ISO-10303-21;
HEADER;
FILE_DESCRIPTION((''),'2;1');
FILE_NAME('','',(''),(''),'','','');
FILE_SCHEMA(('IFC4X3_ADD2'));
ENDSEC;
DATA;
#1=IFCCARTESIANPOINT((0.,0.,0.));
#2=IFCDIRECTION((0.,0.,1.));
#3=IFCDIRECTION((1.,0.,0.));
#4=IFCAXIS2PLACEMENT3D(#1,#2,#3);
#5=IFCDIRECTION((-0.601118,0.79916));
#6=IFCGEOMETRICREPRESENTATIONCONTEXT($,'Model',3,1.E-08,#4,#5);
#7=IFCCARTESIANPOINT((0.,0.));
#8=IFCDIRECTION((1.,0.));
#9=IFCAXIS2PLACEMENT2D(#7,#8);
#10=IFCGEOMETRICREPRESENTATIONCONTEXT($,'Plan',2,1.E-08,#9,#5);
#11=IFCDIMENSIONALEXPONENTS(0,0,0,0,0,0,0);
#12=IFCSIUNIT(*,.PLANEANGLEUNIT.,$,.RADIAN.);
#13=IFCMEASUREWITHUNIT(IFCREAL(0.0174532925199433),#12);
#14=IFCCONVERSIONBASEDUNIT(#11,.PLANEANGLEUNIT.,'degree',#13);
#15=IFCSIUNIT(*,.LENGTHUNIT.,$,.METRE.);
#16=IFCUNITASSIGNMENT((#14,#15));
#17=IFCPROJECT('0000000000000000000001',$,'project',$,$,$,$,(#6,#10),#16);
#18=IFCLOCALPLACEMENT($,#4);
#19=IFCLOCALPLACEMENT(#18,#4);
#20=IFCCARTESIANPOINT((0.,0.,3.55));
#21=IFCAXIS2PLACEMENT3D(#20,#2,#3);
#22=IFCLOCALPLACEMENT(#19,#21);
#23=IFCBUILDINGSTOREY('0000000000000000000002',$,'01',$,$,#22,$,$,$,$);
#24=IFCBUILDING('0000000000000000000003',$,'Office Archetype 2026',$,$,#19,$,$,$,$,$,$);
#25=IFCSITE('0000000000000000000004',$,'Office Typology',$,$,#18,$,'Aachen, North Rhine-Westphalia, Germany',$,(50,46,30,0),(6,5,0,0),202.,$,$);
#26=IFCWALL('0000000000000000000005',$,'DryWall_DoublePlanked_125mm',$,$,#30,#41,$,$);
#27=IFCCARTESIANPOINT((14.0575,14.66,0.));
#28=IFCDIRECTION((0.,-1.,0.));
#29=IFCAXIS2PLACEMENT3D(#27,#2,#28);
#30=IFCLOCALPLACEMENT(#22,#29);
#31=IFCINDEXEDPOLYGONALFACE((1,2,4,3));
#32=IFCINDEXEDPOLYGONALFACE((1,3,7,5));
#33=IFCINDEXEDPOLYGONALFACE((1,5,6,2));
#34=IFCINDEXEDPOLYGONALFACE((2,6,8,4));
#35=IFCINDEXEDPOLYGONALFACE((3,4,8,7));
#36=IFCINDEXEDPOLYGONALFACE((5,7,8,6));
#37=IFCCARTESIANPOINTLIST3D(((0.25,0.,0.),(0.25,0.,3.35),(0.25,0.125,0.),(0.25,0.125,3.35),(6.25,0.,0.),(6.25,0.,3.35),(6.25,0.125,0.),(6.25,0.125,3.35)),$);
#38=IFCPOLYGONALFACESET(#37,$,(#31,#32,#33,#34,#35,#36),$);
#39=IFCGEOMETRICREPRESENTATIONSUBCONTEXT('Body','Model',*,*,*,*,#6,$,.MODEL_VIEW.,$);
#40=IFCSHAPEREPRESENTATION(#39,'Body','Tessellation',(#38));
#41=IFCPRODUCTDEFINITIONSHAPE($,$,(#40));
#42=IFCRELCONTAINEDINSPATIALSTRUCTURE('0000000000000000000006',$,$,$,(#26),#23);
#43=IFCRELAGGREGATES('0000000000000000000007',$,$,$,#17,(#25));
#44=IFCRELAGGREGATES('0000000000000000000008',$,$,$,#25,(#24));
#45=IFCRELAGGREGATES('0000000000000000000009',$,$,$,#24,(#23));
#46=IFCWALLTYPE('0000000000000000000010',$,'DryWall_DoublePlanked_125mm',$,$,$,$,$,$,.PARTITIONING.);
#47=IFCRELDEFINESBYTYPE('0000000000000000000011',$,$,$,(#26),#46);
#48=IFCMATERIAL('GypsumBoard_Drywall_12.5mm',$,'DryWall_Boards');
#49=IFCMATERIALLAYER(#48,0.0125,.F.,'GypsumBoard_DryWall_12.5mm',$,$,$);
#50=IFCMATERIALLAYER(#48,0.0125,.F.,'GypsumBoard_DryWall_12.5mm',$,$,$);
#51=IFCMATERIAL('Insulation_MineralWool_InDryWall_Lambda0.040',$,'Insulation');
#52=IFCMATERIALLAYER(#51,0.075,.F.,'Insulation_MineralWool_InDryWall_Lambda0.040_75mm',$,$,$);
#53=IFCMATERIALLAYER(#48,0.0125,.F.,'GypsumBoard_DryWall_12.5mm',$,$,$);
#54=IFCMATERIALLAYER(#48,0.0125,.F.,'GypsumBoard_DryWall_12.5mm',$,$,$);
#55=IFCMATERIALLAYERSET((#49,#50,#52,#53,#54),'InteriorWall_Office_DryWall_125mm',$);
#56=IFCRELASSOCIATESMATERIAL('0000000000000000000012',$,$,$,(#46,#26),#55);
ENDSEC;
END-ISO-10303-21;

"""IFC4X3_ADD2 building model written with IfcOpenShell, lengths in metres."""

from ifc_helpers import new_model, entity, si_unit, converted_unit, direction, frame, origin_with_axes, origin_2d_with_axis, place, context, subcontext, project, spatial, line, indexed_curve, outline, extrude, material, layer, layer_set, layer_usage, type_object, element, save


model = new_model("IFC4X3_ADD2")

# Units and contexts
model_context = context("Model", 3, precision=1e-08, world=origin_with_axes(), true_north=direction((-0.601118, 0.79916)))
plan_context = context("Plan", 2, precision=1e-08, world=origin_2d_with_axis(), true_north=direction((-0.601118, 0.79916)))
body_context = subcontext(model_context, "Body", "Model", "MODEL_VIEW")
ifc_project = project(units=[converted_unit("PLANEANGLEUNIT", "degree", entity("IfcReal", 0.0174532925199433), si_unit("PLANEANGLEUNIT", "RADIAN"), dimensions=[0, 0, 0, 0, 0, 0, 0]), si_unit("LENGTHUNIT", "METRE")], contexts=[model_context, plan_context])

# Site, building, storey
site_placement = place(None, origin_with_axes())
site = spatial("IfcSite", under=ifc_project, at=site_placement, Name="Office Typology", LongName="Aachen, North Rhine-Westphalia, Germany", RefLatitude=(50, 46, 30, 0), RefLongitude=(6, 5, 0, 0), RefElevation=202.0)
building_placement = place(site_placement, origin_with_axes())
building = spatial("IfcBuilding", under=site, at=building_placement, Name="Office Archetype 2026")
storey_placement = place(building_placement, frame((0.0, 0.0, 3.55), z_axis=(0.0, 0.0, 1.0), x_axis=(1.0, 0.0, 0.0)))
storey = spatial("IfcBuildingStorey", under=building, at=storey_placement, Name="01")

# Wall
ifc_material_1 = material(Name="GypsumBoard_Drywall_12.5mm", Category="DryWall_Boards")
ifc_layer_1 = layer(ifc_material_1, 0.0125, ventilated=False, Name="GypsumBoard_DryWall_12.5mm")
ifc_layer_2 = layer(ifc_material_1, 0.0125, ventilated=False, Name="GypsumBoard_DryWall_12.5mm")
ifc_material_2 = material(Name="Insulation_MineralWool_InDryWall_Lambda0.040", Category="Insulation")
ifc_layer_3 = layer(ifc_material_2, 0.075, ventilated=False, Name="Insulation_MineralWool_InDryWall_Lambda0.040_75mm")
ifc_layer_4 = layer(ifc_material_1, 0.0125, ventilated=False, Name="GypsumBoard_DryWall_12.5mm")
ifc_layer_5 = layer(ifc_material_1, 0.0125, ventilated=False, Name="GypsumBoard_DryWall_12.5mm")
ifc_layer_set_1 = layer_set([ifc_layer_1, ifc_layer_2, ifc_layer_3, ifc_layer_4, ifc_layer_5], Name="InteriorWall_Office_DryWall_125mm")
ifc_layer_usage = layer_usage(ifc_layer_set_1, "AXIS2", "POSITIVE", 0.0)
wall_type_1 = type_object("IfcWallType", Name="DryWall_DoublePlanked_125mm", PredefinedType="PARTITIONING", material=ifc_layer_set_1)
wall_1_placement = place(storey_placement, frame((14.0575, 14.66, 0.0), z_axis=(0.0, 0.0, 1.0), x_axis=(0.0, -1.0, 0.0)))
element("IfcWall", 1, at=wall_1_placement, inside=storey, type_object=wall_type_1, material=ifc_layer_usage, Name="DryWall_DoublePlanked_125mm", context=body_context, shape_type="SweptSolid", body=[
    extrude(outline(indexed_curve([(0.25, 0.0), (0.25, 0.125), (6.25, 0.125), (6.25, 0.0)], segments=[line(1, 2, 3, 4, 1)])), origin_with_axes(), (0.0, 0.0, 1.0), 3.35),
])

save(model, "model.ifc")
